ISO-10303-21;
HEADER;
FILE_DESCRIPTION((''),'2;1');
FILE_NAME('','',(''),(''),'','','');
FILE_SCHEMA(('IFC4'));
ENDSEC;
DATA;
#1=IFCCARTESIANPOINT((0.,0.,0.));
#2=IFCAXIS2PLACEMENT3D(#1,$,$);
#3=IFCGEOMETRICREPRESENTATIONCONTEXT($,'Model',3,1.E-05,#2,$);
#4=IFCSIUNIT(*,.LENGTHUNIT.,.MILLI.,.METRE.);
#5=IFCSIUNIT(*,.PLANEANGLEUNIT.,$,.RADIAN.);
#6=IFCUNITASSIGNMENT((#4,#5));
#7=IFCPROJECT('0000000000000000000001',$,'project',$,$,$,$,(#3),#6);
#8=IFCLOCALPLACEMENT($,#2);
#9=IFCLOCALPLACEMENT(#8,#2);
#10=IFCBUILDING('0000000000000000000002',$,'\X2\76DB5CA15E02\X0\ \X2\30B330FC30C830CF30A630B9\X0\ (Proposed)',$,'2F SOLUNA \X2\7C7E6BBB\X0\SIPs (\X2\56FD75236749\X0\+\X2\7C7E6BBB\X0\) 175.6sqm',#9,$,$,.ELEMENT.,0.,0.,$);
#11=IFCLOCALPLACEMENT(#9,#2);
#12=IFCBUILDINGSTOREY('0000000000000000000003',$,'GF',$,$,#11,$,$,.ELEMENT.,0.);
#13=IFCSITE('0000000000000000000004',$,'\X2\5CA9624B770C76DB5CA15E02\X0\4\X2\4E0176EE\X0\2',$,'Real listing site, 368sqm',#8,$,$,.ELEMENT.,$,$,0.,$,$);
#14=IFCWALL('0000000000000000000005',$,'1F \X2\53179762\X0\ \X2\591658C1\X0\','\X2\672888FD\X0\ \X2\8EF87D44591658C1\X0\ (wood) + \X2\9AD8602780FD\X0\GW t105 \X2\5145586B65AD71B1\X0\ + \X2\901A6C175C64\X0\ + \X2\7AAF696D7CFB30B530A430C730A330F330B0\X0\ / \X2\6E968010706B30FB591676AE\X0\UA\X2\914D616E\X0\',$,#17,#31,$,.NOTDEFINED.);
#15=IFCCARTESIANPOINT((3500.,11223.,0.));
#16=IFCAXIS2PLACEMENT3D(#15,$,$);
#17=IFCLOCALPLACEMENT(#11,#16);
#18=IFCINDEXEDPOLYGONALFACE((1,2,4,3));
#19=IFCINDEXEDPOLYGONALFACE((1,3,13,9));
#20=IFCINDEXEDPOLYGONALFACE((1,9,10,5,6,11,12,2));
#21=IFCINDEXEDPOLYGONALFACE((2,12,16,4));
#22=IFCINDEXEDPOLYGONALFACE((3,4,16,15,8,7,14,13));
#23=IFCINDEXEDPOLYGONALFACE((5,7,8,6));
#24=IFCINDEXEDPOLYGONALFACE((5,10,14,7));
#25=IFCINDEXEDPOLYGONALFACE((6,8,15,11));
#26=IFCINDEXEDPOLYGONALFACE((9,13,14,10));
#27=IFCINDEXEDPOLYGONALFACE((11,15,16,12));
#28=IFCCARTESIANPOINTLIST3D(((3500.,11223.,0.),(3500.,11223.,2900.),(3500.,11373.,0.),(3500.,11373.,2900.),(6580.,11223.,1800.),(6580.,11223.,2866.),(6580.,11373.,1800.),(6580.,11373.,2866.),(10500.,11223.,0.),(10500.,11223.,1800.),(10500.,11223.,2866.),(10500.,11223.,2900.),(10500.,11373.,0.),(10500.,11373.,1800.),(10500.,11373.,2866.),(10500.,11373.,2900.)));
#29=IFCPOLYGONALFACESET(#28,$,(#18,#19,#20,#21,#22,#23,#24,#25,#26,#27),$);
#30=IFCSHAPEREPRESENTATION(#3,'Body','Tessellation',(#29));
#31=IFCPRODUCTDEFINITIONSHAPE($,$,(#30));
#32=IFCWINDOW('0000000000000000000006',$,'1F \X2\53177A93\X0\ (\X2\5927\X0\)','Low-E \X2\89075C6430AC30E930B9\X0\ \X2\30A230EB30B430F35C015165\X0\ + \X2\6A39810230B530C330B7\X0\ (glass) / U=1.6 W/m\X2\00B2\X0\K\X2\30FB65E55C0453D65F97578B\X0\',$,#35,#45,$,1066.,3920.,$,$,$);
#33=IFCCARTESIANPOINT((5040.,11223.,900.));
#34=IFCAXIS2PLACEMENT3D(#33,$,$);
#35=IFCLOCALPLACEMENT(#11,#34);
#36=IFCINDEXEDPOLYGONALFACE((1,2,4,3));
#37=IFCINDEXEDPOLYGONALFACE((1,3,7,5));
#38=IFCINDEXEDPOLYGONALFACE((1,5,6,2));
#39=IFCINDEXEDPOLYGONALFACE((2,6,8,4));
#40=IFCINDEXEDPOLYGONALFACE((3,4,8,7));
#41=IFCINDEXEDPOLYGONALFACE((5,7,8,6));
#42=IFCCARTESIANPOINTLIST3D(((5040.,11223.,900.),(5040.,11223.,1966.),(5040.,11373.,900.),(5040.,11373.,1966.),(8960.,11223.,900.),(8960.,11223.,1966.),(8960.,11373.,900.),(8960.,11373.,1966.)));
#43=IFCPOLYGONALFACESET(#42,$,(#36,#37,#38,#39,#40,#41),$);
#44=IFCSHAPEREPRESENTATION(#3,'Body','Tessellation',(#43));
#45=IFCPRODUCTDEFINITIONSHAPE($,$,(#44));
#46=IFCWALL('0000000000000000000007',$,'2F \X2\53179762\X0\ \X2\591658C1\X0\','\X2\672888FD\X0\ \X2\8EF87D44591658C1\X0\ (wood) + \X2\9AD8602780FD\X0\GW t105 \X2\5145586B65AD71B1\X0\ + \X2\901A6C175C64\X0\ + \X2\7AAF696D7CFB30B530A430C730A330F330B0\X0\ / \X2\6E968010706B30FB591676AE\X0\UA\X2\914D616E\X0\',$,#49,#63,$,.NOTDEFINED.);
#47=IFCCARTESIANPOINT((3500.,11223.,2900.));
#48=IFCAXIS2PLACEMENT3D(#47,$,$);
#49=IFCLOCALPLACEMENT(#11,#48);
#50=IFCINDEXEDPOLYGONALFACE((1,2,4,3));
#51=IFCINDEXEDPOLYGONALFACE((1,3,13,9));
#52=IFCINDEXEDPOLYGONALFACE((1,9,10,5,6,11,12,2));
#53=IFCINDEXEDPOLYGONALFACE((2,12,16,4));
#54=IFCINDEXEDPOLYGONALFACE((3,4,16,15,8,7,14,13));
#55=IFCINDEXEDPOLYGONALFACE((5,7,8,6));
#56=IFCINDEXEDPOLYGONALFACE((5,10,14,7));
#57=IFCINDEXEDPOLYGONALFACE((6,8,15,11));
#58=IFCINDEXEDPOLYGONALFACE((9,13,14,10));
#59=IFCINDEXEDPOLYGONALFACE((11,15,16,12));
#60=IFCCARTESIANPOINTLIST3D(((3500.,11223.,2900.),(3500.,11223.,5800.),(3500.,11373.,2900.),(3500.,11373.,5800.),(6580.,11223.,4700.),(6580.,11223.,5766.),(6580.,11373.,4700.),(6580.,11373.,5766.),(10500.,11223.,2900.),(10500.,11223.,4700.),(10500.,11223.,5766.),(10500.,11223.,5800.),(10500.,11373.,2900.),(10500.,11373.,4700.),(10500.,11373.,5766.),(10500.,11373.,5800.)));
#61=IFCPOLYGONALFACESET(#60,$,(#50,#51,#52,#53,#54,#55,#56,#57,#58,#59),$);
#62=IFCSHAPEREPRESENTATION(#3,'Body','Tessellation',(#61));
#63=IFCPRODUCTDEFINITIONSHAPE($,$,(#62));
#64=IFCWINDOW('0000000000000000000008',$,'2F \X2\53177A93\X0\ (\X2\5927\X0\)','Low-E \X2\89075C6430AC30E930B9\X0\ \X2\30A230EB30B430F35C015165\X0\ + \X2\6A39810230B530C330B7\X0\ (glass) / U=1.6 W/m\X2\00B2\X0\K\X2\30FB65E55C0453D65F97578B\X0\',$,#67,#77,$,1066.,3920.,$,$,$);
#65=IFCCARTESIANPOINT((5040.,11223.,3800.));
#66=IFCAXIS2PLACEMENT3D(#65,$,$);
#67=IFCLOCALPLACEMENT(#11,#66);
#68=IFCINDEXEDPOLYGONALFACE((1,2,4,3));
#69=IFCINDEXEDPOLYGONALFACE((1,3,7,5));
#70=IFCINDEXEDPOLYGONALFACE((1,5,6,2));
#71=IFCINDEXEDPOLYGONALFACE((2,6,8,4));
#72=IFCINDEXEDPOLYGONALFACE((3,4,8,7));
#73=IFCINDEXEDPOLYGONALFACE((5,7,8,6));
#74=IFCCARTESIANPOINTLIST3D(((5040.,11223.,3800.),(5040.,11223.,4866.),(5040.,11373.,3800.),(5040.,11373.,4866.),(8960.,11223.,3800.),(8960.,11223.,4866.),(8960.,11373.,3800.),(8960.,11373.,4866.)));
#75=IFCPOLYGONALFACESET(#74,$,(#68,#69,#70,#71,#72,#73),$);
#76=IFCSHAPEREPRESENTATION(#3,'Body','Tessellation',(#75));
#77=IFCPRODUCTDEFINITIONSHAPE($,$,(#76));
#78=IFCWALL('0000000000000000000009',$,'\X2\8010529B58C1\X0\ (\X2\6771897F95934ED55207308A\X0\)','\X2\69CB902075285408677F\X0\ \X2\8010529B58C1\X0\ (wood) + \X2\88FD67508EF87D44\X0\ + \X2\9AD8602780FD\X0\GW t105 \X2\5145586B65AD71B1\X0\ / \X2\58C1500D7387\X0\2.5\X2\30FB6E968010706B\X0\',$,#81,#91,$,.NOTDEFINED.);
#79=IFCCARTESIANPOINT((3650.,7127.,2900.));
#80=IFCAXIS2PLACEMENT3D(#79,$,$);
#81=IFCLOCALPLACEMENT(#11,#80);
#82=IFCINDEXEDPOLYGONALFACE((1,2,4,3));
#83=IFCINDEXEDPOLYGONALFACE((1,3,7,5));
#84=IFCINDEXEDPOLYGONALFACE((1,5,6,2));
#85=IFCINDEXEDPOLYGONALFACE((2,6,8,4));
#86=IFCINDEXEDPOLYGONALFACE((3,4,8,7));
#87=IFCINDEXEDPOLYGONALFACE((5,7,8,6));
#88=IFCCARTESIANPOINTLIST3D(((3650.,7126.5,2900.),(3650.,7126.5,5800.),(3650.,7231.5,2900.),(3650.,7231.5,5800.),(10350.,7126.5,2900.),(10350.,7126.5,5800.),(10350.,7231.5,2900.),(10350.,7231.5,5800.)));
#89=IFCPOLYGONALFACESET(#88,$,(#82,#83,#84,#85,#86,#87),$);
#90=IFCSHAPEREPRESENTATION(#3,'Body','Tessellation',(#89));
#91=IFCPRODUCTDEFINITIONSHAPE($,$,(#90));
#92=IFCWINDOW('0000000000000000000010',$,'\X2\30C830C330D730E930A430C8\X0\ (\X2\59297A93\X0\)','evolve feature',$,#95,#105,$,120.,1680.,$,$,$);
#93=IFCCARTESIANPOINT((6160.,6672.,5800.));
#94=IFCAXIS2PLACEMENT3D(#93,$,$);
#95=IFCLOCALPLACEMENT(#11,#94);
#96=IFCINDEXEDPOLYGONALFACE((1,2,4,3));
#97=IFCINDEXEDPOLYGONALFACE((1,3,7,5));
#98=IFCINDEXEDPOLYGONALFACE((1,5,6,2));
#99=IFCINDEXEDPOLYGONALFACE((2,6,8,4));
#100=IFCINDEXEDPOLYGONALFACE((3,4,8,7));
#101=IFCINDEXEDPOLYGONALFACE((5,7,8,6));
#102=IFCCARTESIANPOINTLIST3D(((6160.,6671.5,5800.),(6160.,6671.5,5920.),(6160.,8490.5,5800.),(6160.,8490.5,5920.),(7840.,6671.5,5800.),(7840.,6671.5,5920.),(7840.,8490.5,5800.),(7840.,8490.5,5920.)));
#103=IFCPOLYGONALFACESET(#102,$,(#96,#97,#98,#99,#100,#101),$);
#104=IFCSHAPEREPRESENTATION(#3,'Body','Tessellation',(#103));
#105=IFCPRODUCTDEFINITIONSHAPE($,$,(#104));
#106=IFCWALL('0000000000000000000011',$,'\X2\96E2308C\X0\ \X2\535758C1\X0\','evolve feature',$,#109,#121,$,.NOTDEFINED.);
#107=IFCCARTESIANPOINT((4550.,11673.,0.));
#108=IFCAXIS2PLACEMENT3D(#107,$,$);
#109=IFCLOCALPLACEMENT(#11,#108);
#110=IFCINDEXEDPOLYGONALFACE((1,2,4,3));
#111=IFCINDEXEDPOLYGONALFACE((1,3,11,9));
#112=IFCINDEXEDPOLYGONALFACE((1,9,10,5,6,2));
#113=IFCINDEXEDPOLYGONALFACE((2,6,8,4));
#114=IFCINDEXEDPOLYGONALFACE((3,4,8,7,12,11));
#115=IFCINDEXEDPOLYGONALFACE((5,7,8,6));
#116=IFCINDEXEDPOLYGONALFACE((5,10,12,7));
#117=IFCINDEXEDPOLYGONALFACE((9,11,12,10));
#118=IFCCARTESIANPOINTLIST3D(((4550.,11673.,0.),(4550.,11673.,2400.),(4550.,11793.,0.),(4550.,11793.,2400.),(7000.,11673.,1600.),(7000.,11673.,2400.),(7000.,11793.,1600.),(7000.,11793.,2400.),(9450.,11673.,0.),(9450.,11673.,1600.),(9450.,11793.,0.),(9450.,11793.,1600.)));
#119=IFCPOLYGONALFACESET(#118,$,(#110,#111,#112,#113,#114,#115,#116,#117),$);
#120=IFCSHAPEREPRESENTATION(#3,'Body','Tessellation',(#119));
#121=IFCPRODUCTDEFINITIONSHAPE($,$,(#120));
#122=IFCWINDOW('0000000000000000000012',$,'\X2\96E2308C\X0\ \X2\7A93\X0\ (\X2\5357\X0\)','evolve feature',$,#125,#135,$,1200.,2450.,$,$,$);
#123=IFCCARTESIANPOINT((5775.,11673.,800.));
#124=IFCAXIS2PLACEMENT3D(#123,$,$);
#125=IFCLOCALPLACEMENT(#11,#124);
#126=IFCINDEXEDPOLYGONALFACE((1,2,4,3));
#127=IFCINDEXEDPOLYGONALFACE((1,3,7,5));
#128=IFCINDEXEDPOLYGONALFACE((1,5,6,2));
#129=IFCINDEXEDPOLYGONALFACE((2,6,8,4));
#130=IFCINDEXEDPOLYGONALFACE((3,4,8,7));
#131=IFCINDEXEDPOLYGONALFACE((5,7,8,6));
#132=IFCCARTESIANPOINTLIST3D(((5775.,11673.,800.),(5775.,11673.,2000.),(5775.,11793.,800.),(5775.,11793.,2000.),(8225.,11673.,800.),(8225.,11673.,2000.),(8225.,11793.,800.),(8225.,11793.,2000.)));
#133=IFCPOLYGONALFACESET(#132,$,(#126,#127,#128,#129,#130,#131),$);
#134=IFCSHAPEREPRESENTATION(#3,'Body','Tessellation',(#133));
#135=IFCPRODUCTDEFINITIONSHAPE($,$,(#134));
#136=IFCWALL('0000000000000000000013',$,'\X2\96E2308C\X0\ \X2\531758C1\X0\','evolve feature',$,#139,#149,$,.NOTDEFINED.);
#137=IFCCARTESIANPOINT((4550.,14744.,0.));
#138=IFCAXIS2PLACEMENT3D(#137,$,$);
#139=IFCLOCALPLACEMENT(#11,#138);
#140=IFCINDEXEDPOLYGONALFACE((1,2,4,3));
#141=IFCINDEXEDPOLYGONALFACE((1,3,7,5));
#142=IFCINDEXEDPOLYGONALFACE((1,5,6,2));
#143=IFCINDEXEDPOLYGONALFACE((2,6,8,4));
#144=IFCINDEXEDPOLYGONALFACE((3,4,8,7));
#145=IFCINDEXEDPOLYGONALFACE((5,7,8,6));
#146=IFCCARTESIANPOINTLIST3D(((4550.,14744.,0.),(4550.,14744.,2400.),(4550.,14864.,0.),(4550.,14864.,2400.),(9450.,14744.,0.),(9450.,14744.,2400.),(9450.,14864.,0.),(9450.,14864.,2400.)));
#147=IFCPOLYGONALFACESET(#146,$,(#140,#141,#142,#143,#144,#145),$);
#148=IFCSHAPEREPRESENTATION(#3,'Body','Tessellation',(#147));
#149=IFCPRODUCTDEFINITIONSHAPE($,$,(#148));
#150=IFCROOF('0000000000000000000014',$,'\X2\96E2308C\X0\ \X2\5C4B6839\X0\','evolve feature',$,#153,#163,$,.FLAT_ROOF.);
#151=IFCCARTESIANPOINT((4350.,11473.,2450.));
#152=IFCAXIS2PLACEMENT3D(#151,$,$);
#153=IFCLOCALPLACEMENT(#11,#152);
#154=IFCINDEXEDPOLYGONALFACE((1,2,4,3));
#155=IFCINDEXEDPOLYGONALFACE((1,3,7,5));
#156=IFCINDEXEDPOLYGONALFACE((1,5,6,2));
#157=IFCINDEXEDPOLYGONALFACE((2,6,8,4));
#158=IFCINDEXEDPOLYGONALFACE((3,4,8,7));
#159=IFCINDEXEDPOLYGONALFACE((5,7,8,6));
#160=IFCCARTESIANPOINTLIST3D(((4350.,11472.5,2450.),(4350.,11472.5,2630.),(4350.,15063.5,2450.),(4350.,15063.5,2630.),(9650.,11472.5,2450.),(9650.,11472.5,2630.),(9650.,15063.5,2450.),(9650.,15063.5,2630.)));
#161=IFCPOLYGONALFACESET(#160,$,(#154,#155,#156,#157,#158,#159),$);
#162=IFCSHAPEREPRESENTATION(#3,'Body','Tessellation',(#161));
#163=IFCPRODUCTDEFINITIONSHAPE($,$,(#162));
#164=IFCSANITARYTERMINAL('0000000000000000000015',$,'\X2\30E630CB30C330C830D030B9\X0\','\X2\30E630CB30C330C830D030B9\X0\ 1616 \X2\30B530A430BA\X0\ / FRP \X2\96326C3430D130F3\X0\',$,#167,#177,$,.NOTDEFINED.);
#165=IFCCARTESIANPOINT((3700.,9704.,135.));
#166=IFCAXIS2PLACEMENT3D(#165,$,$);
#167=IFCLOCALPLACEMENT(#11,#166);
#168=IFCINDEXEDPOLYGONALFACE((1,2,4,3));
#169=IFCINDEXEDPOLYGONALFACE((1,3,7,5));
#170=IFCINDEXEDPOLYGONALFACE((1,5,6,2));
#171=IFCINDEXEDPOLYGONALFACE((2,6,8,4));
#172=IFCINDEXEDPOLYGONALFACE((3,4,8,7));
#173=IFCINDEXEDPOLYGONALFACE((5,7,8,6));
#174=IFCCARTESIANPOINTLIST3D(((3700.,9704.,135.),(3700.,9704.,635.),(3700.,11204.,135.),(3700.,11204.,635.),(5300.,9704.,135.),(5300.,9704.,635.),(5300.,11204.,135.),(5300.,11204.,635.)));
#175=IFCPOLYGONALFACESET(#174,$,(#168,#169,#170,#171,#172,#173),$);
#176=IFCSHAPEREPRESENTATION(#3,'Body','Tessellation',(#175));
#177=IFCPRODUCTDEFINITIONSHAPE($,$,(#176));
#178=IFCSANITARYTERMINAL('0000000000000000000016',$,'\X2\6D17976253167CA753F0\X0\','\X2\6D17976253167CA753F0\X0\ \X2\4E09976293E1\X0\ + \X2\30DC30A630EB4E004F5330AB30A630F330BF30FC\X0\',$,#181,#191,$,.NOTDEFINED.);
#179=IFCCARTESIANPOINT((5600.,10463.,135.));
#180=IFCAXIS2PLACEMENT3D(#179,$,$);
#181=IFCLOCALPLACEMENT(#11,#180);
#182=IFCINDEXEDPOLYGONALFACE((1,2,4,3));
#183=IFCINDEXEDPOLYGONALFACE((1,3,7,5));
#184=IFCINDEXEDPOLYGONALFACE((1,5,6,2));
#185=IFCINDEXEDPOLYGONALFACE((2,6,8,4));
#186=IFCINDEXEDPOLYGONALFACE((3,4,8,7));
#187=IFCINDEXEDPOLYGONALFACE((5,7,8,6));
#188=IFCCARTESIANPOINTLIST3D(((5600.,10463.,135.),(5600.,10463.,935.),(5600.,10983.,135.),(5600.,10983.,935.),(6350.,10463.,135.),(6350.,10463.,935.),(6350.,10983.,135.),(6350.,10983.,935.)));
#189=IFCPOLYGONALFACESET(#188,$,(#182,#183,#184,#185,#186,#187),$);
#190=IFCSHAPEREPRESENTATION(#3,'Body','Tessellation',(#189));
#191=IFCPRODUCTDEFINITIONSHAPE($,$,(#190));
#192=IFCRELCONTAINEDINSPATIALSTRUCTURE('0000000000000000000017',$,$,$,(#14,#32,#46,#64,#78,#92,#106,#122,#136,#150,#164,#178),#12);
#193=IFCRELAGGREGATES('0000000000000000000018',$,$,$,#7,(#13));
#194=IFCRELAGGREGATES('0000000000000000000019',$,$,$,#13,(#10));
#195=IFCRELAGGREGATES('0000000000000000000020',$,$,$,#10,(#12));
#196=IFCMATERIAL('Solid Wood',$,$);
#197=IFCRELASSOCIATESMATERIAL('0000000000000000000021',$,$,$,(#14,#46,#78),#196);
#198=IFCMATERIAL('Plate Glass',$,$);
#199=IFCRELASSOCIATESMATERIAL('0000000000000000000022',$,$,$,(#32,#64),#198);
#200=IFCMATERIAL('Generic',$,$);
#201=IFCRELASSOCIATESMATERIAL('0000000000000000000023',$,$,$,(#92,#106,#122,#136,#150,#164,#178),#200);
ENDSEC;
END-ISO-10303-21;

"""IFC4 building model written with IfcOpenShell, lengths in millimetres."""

from ifc_helpers import new_model, si_unit, frame, frame_2d, origin, place, context, project, spatial, rectangle, extrude, material, element, fill, save


model = new_model("IFC4")

# Units and contexts
model_context = context("Model", 3, precision=1e-05, world=origin())
ifc_project = project(units=[si_unit("LENGTHUNIT", "METRE", prefix="MILLI"), si_unit("PLANEANGLEUNIT", "RADIAN")], contexts=[model_context])

# Site, building, storey
site_placement = place(None, origin())
site = spatial("IfcSite", under=ifc_project, at=site_placement, Name="岩手県盛岡市4丁目2", ObjectType="Real listing site, 368sqm", CompositionType="ELEMENT", RefElevation=0.0)
building_placement = place(site_placement, origin())
building = spatial("IfcBuilding", under=site, at=building_placement, Name="盛岡市 コートハウス (Proposed)", ObjectType="2F SOLUNA 籾殻SIPs (国産杉+籾殻) 175.6sqm", CompositionType="ELEMENT", ElevationOfRefHeight=0.0, ElevationOfTerrain=0.0)
storey_placement = place(building_placement, origin())
storey = spatial("IfcBuildingStorey", under=building, at=storey_placement, Name="GF", CompositionType="ELEMENT", Elevation=0.0)

# Shared definitions
ifc_material_1 = material(Name="Generic")

# Wall, opening, window
ifc_material_2 = material(Name="Solid Wood")
wall_1_placement = place(storey_placement, frame((3500.0, 11223.0, 0.0)))
wall_1 = element("IfcWall", 1, at=wall_1_placement, inside=storey, material=ifc_material_2, Name="1F 北面 外壁", Description="木製 軸組外壁 (wood) + 高性能GW t105 充填断熱 + 通気層 + 窯業系サイディング / 準耐火・外皮UA配慮", PredefinedType="NOTDEFINED", context=model_context, shape_type="SweptSolid", body=[
    extrude(rectangle(XDim=7000.0, YDim=150.0, at=frame_2d((3500.0, 75.0))), frame((3500.0, 11223.0, 0.0)), (0.0, 0.0, 1.0), 2900.0),
])
opening_1_placement = place(storey_placement, frame((5040.0, 11223.0, 900.0)))
opening_1 = element("IfcOpeningElement", 2, at=opening_1_placement, cuts=wall_1, PredefinedType="NOTDEFINED", context=model_context, shape_type="SweptSolid", body=[
    extrude(rectangle(XDim=3920.0, YDim=150.0, at=frame_2d((1960.0, 75.0))), frame((5040.0, 11223.0, 900.0)), (0.0, 0.0, 1.0), 1066.0),
])
ifc_material_3 = material(Name="Plate Glass")
window_1_placement = place(storey_placement, frame((5040.0, 11223.0, 900.0)))
window_1 = element("IfcWindow", 3, at=window_1_placement, inside=storey, material=ifc_material_3, Name="1F 北窓 (大)", Description="Low-E 複層ガラス アルゴン封入 + 樹脂サッシ (glass) / U=1.6 W/m²K・日射取得型", OverallHeight=1066.0, OverallWidth=3920.0, context=model_context, shape_type="SweptSolid", body=[
    extrude(rectangle(XDim=3920.0, YDim=150.0, at=frame_2d((1960.0, 75.0))), frame((5040.0, 11223.0, 900.0)), (0.0, 0.0, 1.0), 1066.0),
])
fill(opening_1, window_1)

# Wall, opening, window
wall_2_placement = place(storey_placement, frame((3500.0, 11223.0, 2900.0)))
wall_2 = element("IfcWall", 4, at=wall_2_placement, inside=storey, material=ifc_material_2, Name="2F 北面 外壁", Description="木製 軸組外壁 (wood) + 高性能GW t105 充填断熱 + 通気層 + 窯業系サイディング / 準耐火・外皮UA配慮", PredefinedType="NOTDEFINED", context=model_context, shape_type="SweptSolid", body=[
    extrude(rectangle(XDim=7000.0, YDim=150.0, at=frame_2d((3500.0, 75.0))), frame((3500.0, 11223.0, 2900.0)), (0.0, 0.0, 1.0), 2900.0),
])
opening_2_placement = place(storey_placement, frame((5040.0, 11223.0, 3800.0)))
opening_2 = element("IfcOpeningElement", 5, at=opening_2_placement, cuts=wall_2, PredefinedType="NOTDEFINED", context=model_context, shape_type="SweptSolid", body=[
    extrude(rectangle(XDim=3920.0, YDim=150.0, at=frame_2d((1960.0, 75.0))), frame((5040.0, 11223.0, 3800.0)), (0.0, 0.0, 1.0), 1066.0),
])
window_2_placement = place(storey_placement, frame((5040.0, 11223.0, 3800.0)))
window_2 = element("IfcWindow", 6, at=window_2_placement, inside=storey, material=ifc_material_3, Name="2F 北窓 (大)", Description="Low-E 複層ガラス アルゴン封入 + 樹脂サッシ (glass) / U=1.6 W/m²K・日射取得型", OverallHeight=1066.0, OverallWidth=3920.0, context=model_context, shape_type="SweptSolid", body=[
    extrude(rectangle(XDim=3920.0, YDim=150.0, at=frame_2d((1960.0, 75.0))), frame((5040.0, 11223.0, 3800.0)), (0.0, 0.0, 1.0), 1066.0),
])
fill(opening_2, window_2)

# Wall
wall_3_placement = place(storey_placement, frame((3650.0, 7127.0, 2900.0)))
element("IfcWall", 7, at=wall_3_placement, inside=storey, material=ifc_material_2, Name="耐力壁 (東西間仕切り)", Description="構造用合板 耐力壁 (wood) + 製材軸組 + 高性能GW t105 充填断熱 / 壁倍率2.5・準耐火", PredefinedType="NOTDEFINED", context=model_context, shape_type="SweptSolid", body=[
    extrude(rectangle(XDim=6700.0, YDim=105.0, at=frame_2d((3350.0, 52.0))), frame((3650.0, 7127.0, 2900.0)), (0.0, 0.0, 1.0), 2900.0),
])

# Window
window_3_placement = place(storey_placement, frame((6160.0, 6672.0, 5800.0)))
element("IfcWindow", 8, at=window_3_placement, inside=storey, material=ifc_material_1, Name="トップライト (天窓)", Description="evolve feature", OverallHeight=120.0, OverallWidth=1680.0, context=model_context, shape_type="SweptSolid", body=[
    extrude(rectangle(XDim=1680.0, YDim=1819.0, at=frame_2d((840.0, 909.0))), frame((6160.0, 6672.0, 5800.0)), (0.0, 0.0, 1.0), 120.0),
])

# Wall, opening, window
wall_4_placement = place(storey_placement, frame((4550.0, 11673.0, 0.0)))
wall_4 = element("IfcWall", 9, at=wall_4_placement, inside=storey, material=ifc_material_1, Name="離れ 南壁", Description="evolve feature", PredefinedType="NOTDEFINED", context=model_context, shape_type="SweptSolid", body=[
    extrude(rectangle(XDim=4900.0, YDim=120.0, at=frame_2d((2450.0, 60.0))), frame((4550.0, 11673.0, 0.0)), (0.0, 0.0, 1.0), 2400.0),
])
opening_3_placement = place(storey_placement, frame((5775.0, 11673.0, 800.0)))
opening_3 = element("IfcOpeningElement", 10, at=opening_3_placement, cuts=wall_4, PredefinedType="NOTDEFINED", context=model_context, shape_type="SweptSolid", body=[
    extrude(rectangle(XDim=2450.0, YDim=120.0, at=frame_2d((1225.0, 60.0))), frame((5775.0, 11673.0, 800.0)), (0.0, 0.0, 1.0), 1200.0),
])
window_4_placement = place(storey_placement, frame((5775.0, 11673.0, 800.0)))
window_4 = element("IfcWindow", 11, at=window_4_placement, inside=storey, material=ifc_material_1, Name="離れ 窓 (南)", Description="evolve feature", OverallHeight=1200.0, OverallWidth=2450.0, context=model_context, shape_type="SweptSolid", body=[
    extrude(rectangle(XDim=2450.0, YDim=120.0, at=frame_2d((1225.0, 60.0))), frame((5775.0, 11673.0, 800.0)), (0.0, 0.0, 1.0), 1200.0),
])
fill(opening_3, window_4)

# Wall
wall_5_placement = place(storey_placement, frame((4550.0, 14744.0, 0.0)))
element("IfcWall", 12, at=wall_5_placement, inside=storey, material=ifc_material_1, Name="離れ 北壁", Description="evolve feature", PredefinedType="NOTDEFINED", context=model_context, shape_type="SweptSolid", body=[
    extrude(rectangle(XDim=4900.0, YDim=120.0, at=frame_2d((2450.0, 60.0))), frame((4550.0, 14744.0, 0.0)), (0.0, 0.0, 1.0), 2400.0),
])

# Roof
roof_placement = place(storey_placement, frame((4350.0, 11473.0, 2450.0)))
element("IfcRoof", 13, at=roof_placement, inside=storey, material=ifc_material_1, Name="離れ 屋根", Description="evolve feature", PredefinedType="FLAT_ROOF", context=model_context, shape_type="SweptSolid", body=[
    extrude(rectangle(XDim=5300.0, YDim=3591.0, at=frame_2d((2650.0, 1795.0))), frame((4350.0, 11473.0, 2450.0)), (0.0, 0.0, 1.0), 180.0),
])

# Sanitary terminals
sanitary_terminal_1_placement = place(storey_placement, frame((3700.0, 9704.0, 135.0)))
element("IfcSanitaryTerminal", 14, at=sanitary_terminal_1_placement, inside=storey, material=ifc_material_1, Name="ユニットバス", Description="ユニットバス 1616 サイズ / FRP 防水パン", PredefinedType="NOTDEFINED", context=model_context, shape_type="SweptSolid", body=[
    extrude(rectangle(XDim=1600.0, YDim=1500.0, at=frame_2d((800.0, 750.0))), frame((3700.0, 9704.0, 135.0)), (0.0, 0.0, 1.0), 500.0),
])
sanitary_terminal_2_placement = place(storey_placement, frame((5600.0, 10463.0, 135.0)))
element("IfcSanitaryTerminal", 15, at=sanitary_terminal_2_placement, inside=storey, material=ifc_material_1, Name="洗面化粧台", Description="洗面化粧台 三面鏡 + ボウル一体カウンター", PredefinedType="NOTDEFINED", context=model_context, shape_type="SweptSolid", body=[
    extrude(rectangle(XDim=750.0, YDim=520.0, at=frame_2d((375.0, 260.0))), frame((5600.0, 10463.0, 135.0)), (0.0, 0.0, 1.0), 800.0),
])

save(model, "model.ifc")
